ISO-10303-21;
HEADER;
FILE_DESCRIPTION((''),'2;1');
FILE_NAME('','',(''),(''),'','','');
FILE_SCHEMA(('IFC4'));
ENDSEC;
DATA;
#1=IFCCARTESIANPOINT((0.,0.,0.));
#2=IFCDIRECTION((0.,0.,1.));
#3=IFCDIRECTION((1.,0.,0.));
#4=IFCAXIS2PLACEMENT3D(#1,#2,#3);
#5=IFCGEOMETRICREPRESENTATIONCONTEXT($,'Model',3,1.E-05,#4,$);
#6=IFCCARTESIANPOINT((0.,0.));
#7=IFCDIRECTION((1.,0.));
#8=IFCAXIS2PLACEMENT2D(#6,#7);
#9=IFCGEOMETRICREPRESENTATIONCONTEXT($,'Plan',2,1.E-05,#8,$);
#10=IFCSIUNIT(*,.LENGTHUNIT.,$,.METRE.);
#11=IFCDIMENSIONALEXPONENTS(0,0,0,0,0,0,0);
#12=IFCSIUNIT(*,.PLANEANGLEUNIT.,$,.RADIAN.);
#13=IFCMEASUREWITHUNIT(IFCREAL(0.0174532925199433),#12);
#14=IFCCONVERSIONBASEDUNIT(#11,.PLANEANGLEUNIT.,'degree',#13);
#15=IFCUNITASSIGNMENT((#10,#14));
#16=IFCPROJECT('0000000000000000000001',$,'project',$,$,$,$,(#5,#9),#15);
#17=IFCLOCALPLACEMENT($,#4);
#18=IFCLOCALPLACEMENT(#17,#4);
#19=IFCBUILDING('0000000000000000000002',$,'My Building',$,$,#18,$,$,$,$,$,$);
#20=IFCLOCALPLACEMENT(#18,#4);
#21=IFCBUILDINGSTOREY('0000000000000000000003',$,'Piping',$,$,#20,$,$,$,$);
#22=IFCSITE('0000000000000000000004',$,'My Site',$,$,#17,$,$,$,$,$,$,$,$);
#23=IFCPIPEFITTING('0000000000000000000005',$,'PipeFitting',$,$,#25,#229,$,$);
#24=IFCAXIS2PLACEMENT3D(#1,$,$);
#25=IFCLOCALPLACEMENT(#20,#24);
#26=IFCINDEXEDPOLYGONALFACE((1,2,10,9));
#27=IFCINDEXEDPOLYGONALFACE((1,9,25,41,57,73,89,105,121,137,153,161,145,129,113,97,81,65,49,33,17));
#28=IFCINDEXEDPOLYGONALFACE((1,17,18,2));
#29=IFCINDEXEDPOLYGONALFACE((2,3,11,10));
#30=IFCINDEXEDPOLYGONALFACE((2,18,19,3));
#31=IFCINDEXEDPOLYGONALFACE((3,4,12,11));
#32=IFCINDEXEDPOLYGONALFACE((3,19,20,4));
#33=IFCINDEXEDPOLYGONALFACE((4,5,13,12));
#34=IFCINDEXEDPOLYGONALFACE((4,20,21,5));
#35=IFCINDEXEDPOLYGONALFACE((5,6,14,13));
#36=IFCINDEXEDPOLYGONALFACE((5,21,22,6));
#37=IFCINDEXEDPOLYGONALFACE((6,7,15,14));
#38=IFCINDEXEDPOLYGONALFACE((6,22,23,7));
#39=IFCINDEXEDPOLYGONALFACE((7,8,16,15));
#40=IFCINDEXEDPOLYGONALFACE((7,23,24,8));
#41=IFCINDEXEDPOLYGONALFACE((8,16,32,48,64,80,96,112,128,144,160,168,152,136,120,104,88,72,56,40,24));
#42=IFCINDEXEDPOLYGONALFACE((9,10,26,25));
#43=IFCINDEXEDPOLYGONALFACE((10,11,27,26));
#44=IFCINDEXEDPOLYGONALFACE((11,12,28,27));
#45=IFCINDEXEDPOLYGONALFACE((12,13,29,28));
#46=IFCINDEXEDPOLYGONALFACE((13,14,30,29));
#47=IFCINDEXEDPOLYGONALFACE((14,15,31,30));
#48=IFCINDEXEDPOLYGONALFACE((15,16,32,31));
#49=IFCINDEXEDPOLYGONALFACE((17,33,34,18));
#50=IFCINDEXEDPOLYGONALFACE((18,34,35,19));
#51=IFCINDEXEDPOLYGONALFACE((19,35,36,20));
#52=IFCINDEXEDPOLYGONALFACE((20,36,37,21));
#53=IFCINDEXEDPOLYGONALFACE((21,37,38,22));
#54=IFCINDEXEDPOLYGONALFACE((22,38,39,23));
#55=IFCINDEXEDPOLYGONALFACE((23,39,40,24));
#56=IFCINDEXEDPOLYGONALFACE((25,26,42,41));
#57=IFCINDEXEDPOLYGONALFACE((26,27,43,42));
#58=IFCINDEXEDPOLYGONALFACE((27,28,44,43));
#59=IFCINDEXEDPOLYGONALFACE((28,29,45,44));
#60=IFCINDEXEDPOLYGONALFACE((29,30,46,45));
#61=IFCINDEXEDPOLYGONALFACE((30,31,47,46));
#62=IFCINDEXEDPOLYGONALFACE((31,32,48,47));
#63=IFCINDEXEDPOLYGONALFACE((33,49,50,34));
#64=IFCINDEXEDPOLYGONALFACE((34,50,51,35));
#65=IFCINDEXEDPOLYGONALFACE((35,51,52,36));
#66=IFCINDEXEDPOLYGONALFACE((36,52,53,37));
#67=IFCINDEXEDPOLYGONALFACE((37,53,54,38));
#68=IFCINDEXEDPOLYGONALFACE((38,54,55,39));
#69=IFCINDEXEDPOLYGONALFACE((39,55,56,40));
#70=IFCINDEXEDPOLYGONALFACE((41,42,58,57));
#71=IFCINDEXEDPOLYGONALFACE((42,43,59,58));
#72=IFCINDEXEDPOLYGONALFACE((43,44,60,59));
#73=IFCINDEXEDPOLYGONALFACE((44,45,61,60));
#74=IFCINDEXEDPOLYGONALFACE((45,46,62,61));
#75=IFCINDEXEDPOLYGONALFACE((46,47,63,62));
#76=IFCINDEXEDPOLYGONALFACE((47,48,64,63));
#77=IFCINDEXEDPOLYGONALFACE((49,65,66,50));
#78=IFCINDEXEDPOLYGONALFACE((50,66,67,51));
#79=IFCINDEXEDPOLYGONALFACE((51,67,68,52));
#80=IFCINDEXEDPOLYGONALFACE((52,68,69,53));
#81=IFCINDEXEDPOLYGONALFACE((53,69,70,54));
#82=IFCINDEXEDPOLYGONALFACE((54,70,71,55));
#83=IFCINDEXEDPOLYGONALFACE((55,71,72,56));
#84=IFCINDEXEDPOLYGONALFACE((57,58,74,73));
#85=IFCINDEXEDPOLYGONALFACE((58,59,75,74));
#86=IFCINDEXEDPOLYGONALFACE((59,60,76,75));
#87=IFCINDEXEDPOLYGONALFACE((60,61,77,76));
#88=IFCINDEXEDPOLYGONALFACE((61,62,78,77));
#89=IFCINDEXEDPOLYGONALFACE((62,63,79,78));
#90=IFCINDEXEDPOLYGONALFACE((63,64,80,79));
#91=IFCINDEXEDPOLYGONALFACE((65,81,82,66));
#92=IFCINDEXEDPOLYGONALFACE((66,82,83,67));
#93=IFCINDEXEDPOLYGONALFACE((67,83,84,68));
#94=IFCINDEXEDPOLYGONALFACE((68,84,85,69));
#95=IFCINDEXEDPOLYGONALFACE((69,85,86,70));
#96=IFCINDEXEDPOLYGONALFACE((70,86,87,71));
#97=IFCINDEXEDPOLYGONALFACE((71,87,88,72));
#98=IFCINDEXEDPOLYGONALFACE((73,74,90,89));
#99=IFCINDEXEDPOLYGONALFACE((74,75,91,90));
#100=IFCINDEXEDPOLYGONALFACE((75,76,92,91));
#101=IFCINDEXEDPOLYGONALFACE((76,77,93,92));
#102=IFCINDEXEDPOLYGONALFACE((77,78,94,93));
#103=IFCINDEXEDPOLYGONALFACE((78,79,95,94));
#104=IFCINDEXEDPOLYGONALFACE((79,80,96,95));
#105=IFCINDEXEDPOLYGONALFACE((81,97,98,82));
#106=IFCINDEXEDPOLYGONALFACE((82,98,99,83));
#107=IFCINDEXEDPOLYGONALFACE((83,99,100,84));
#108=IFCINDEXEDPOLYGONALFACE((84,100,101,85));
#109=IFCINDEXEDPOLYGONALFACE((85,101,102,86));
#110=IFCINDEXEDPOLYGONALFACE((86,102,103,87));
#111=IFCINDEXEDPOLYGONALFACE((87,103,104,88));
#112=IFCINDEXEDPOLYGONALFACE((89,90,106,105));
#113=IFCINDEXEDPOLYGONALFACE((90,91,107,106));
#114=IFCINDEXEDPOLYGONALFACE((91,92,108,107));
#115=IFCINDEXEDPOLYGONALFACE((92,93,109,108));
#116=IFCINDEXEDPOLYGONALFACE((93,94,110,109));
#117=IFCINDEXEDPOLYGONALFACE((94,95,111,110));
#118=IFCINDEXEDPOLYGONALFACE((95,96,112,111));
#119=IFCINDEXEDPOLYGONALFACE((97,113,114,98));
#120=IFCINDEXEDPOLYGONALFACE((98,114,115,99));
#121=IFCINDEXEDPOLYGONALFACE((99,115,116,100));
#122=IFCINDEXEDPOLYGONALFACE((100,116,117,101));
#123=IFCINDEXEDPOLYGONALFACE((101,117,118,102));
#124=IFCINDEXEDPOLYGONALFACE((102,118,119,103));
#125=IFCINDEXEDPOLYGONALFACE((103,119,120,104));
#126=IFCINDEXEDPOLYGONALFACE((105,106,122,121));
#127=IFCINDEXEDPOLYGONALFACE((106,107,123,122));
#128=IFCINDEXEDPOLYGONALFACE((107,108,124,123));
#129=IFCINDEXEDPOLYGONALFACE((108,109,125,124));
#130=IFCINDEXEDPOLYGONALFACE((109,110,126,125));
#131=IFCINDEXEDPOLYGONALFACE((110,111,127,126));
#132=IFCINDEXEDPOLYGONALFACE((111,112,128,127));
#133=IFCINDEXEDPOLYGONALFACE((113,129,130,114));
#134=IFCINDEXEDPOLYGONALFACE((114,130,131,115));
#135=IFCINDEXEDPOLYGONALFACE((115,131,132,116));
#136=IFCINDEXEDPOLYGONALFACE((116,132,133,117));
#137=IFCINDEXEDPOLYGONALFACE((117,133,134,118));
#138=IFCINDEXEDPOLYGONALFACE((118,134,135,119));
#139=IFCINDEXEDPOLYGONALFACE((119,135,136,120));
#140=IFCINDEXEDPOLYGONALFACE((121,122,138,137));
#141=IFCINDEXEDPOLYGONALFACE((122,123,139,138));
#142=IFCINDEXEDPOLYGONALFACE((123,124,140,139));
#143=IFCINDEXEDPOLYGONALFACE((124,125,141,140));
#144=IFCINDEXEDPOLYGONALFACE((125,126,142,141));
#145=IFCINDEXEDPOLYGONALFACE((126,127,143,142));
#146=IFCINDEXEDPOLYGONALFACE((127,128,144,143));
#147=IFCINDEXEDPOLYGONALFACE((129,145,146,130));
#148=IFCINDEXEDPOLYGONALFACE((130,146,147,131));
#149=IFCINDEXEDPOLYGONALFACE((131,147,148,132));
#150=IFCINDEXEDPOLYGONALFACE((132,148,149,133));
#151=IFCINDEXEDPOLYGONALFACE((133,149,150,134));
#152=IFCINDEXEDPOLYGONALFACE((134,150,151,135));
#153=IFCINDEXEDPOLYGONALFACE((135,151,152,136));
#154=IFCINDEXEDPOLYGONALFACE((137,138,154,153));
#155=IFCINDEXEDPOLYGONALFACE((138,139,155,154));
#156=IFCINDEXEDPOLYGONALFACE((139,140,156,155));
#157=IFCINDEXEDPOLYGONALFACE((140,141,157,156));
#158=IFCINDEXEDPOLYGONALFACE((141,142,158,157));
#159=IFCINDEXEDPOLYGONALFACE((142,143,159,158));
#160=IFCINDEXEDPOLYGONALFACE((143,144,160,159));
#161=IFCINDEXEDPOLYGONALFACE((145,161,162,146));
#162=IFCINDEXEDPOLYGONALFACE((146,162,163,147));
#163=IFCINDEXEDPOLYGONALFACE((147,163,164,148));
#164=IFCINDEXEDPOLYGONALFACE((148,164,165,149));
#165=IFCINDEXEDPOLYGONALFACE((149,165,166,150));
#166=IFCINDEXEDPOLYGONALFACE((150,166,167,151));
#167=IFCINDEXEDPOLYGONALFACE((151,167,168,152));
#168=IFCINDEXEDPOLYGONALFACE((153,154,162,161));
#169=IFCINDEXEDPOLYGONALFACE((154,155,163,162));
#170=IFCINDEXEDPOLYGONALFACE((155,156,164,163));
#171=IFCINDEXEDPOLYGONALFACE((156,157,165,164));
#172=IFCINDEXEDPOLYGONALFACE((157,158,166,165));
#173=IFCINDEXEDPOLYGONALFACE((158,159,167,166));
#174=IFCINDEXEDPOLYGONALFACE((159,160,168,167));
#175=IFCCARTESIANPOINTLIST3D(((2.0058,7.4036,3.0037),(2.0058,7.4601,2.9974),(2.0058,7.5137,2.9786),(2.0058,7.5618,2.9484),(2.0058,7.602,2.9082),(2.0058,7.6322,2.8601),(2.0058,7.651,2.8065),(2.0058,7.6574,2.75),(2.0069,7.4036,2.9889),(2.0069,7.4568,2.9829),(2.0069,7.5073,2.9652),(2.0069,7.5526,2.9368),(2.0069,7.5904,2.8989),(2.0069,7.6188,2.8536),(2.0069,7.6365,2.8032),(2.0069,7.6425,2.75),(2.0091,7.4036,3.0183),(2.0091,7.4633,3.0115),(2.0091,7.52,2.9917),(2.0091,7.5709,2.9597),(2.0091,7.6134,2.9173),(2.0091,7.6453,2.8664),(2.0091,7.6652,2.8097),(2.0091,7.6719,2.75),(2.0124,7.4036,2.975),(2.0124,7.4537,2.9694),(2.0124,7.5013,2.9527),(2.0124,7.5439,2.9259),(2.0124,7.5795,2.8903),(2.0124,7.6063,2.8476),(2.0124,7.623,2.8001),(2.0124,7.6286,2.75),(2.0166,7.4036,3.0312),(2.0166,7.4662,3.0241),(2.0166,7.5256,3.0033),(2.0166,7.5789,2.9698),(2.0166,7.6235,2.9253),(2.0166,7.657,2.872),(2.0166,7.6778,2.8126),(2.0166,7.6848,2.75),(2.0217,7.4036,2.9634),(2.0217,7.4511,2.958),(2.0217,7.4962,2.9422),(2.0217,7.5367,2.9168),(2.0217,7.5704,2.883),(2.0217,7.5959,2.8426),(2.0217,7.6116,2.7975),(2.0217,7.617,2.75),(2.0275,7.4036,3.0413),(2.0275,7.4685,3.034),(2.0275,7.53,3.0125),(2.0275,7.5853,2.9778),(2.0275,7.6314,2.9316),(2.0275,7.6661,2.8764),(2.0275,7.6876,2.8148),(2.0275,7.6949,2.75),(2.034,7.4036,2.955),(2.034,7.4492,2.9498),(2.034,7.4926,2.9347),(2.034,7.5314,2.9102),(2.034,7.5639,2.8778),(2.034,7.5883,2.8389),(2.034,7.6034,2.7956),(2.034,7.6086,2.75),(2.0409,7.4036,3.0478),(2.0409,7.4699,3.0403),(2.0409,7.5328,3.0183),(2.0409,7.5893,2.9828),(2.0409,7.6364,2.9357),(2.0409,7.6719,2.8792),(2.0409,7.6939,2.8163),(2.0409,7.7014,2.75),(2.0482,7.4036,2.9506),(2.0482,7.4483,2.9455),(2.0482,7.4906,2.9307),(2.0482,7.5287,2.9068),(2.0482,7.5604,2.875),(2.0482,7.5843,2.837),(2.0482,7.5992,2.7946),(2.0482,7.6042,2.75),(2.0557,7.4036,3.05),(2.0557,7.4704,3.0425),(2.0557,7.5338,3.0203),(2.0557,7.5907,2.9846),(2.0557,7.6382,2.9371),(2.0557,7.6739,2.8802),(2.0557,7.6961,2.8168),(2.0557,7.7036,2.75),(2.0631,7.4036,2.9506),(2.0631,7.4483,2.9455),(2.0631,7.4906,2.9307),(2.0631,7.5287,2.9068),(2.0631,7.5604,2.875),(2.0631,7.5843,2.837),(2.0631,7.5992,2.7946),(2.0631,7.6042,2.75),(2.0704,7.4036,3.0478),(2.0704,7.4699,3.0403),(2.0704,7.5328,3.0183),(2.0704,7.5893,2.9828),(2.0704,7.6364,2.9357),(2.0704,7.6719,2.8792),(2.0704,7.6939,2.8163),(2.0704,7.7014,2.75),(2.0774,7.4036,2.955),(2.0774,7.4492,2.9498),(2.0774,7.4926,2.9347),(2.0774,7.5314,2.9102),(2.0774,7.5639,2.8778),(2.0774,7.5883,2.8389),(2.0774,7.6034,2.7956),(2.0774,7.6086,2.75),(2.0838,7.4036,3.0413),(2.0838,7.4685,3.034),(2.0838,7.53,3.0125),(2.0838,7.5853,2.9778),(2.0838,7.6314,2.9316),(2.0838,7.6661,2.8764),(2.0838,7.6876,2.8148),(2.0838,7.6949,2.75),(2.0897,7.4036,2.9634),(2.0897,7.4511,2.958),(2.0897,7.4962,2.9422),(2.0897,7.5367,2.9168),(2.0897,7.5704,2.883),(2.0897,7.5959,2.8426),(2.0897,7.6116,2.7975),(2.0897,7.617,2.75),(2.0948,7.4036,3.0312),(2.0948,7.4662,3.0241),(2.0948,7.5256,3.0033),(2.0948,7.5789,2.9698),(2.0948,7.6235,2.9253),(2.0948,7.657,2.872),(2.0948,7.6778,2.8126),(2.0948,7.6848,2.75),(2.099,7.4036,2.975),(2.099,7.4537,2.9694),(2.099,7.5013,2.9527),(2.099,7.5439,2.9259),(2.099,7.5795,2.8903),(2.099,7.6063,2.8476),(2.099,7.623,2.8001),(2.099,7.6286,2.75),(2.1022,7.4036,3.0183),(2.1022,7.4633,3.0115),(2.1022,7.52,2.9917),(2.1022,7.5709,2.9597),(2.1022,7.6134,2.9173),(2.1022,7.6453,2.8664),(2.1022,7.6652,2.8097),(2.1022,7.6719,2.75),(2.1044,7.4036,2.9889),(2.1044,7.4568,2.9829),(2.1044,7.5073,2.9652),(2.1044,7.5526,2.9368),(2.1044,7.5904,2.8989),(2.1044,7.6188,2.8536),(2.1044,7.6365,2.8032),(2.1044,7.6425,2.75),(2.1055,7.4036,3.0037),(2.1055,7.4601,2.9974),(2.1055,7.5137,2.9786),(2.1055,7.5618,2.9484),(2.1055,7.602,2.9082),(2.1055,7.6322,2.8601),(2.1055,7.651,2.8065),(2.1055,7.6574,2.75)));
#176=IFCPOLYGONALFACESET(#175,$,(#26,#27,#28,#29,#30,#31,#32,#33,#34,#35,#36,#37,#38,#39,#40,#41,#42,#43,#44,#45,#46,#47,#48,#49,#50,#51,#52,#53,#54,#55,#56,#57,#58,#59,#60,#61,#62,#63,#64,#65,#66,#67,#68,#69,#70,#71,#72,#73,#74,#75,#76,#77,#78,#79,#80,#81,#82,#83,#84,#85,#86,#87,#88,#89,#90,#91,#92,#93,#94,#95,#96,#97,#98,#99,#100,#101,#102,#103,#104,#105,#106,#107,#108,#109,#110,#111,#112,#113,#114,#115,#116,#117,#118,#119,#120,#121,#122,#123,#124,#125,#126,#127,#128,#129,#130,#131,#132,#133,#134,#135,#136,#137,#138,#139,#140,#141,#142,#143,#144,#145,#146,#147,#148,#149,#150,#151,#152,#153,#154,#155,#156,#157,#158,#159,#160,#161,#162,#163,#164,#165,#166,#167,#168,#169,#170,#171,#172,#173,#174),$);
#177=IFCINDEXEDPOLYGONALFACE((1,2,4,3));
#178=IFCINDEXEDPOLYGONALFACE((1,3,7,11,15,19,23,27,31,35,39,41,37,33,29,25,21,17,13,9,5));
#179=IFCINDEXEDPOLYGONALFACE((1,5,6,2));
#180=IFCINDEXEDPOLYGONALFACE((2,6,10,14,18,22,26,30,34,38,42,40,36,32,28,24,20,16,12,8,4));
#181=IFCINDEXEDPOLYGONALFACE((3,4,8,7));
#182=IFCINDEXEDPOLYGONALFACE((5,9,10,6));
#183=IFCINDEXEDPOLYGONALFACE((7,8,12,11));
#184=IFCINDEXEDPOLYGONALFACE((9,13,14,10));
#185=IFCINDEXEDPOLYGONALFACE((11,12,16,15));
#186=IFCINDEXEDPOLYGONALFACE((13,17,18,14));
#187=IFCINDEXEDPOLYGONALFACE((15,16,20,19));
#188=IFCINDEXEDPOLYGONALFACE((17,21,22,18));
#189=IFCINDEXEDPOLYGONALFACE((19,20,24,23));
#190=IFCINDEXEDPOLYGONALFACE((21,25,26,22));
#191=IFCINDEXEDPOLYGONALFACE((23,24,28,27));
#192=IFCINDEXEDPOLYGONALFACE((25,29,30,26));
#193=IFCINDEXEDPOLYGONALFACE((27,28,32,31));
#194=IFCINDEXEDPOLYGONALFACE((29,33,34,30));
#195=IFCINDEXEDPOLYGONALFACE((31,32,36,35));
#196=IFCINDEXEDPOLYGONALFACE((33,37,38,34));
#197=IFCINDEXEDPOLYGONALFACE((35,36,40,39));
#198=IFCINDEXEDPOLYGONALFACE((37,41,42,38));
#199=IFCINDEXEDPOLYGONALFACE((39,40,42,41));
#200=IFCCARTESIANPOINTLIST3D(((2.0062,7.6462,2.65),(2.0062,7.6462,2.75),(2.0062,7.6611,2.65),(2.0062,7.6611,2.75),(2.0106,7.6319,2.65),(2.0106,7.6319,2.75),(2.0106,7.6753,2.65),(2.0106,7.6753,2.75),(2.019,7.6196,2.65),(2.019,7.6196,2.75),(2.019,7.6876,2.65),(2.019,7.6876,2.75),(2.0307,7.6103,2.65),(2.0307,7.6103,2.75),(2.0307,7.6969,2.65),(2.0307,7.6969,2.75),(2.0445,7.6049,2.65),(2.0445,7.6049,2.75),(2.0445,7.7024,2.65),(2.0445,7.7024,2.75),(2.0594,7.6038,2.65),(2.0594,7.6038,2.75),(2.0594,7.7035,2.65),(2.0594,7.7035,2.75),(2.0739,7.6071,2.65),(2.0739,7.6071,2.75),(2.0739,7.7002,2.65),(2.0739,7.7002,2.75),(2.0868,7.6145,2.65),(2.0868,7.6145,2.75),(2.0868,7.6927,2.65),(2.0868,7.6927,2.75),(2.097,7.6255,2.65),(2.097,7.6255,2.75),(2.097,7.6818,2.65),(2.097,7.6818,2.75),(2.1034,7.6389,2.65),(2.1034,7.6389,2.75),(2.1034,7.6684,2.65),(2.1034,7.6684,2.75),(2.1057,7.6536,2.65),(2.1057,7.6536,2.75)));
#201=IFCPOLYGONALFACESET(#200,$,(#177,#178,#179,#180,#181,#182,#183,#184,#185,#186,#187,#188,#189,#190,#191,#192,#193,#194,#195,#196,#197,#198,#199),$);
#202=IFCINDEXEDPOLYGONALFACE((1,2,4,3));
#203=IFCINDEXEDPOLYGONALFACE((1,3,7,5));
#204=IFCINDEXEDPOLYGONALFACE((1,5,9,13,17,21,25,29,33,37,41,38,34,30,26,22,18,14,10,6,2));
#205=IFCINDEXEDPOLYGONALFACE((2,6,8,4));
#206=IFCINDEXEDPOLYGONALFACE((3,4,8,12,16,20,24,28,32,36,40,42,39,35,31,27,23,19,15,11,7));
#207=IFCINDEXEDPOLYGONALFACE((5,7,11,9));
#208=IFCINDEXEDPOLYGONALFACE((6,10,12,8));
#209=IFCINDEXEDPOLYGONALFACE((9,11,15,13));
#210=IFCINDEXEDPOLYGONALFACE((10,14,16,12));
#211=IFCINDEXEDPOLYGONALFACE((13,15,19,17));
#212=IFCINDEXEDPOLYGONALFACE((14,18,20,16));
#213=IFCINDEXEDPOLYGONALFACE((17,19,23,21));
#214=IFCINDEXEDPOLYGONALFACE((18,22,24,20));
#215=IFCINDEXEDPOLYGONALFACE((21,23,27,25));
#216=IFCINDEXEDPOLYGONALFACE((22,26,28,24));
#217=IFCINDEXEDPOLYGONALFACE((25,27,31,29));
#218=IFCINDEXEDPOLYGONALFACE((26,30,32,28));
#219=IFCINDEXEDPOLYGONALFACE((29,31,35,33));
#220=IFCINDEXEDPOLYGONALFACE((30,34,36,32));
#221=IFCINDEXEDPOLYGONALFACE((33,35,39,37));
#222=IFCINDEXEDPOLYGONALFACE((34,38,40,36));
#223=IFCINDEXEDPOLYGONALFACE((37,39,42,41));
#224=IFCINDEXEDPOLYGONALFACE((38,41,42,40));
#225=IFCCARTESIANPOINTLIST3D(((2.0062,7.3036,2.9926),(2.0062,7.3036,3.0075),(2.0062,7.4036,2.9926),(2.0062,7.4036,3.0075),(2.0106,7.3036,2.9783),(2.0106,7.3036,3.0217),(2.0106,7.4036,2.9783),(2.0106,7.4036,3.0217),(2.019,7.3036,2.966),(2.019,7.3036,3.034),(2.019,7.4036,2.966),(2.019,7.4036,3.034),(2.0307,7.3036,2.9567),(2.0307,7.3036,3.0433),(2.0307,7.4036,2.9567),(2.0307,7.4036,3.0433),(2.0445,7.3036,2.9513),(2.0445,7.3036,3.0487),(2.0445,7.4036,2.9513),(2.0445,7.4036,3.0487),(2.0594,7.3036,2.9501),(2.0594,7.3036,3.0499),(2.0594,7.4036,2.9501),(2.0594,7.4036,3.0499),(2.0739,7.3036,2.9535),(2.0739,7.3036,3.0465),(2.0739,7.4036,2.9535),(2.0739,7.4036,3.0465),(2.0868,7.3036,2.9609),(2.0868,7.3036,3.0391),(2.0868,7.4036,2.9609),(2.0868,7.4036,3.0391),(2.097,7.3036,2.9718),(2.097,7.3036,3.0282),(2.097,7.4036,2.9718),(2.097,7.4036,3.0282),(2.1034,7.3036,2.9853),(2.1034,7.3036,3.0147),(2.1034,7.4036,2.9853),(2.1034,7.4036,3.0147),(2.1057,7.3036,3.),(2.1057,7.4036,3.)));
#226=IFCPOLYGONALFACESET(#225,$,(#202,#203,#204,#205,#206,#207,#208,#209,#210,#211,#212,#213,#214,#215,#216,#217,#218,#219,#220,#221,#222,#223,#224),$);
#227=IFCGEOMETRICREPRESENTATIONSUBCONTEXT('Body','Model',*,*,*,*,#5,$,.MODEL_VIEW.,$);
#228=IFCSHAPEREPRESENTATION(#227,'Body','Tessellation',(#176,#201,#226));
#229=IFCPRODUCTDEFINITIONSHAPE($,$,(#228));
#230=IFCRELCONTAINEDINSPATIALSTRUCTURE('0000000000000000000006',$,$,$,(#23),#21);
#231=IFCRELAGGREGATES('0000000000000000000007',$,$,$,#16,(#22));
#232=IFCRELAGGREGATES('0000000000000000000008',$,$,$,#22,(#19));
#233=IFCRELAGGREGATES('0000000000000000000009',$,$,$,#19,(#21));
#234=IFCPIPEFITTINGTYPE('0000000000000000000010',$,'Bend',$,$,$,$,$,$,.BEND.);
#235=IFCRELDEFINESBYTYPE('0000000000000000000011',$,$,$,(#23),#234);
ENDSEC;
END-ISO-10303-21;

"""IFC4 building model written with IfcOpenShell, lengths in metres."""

from ifc_helpers import new_model, entity, si_unit, converted_unit, frame, origin_with_axes, origin_2d_with_axis, place, context, subcontext, project, spatial, circle, extrude, source, transform, mapped, type_object, type_shapes, element, save


model = new_model("IFC4")

# Units and contexts
model_context = context("Model", 3, precision=1e-05, world=origin_with_axes())
plan_context = context("Plan", 2, precision=1e-05, world=origin_2d_with_axis())
body_context = subcontext(model_context, "Body", "Model", "MODEL_VIEW")
ifc_project = project(units=[si_unit("LENGTHUNIT", "METRE"), converted_unit("PLANEANGLEUNIT", "degree", entity("IfcReal", 0.0174532925199433), si_unit("PLANEANGLEUNIT", "RADIAN"), dimensions=[0, 0, 0, 0, 0, 0, 0])], contexts=[model_context, plan_context])

# Site, building, storey
site_placement = place(None, origin_with_axes())
site = spatial("IfcSite", under=ifc_project, at=site_placement, Name="My Site")
building_placement = place(site_placement, origin_with_axes())
building = spatial("IfcBuilding", under=site, at=building_placement, Name="My Building")
storey_placement = place(building_placement, origin_with_axes())
storey = spatial("IfcBuildingStorey", under=building, at=storey_placement, Name="Piping")

# Pipe fitting
pipe_fitting_type = type_object("IfcPipeFittingType", Name="Bend", PredefinedType="BEND")
shared_shape = source(origin_with_axes(), body_context, "Body", "SolidModel", [
    entity("IfcSweptDiskSolid", entity("IfcIndexedPolyCurve", entity("IfcCartesianPointList3D", [[0.0, 0.0, -0.1], [0.0, 0.0732, -0.2768], [0.0, 0.25, -0.35]]), [entity("IfcArcIndex", [1, 2, 3])]), 0.05),
    extrude(circle(Radius=0.05), origin_with_axes(), (0.0, 0.0, -1.0), 0.1),
    extrude(circle(Radius=0.05), frame((0.0, 0.25, -0.35), z_axis=(0.0, 1.0, 0.0), x_axis=(1.0, 0.0, 0.0)), (0.0, 0.0, 1.0), 0.1),
])
type_shapes(pipe_fitting_type, [shared_shape])
for number, where, z_axis, x_axis, name in (
    (1, (2.0557, 7.6536, 2.65), (0.0, 0.0, -1.0), (1.0, 0.0, 0.0), "PipeFitting"),
):
    element("IfcPipeFitting", number, at=place(storey_placement, frame(where, z_axis=z_axis, x_axis=x_axis)), inside=storey, type_object=pipe_fitting_type, Name=name, context=body_context, shape_type="MappedRepresentation", body=[
        mapped(shared_shape, transform((0.0, 0.0, 0.0), x_axis=(1.0, 0.0, 0.0), y_axis=(0.0, 1.0, 0.0), z_axis=(0.0, 0.0, 1.0), scale=1.0)),
    ])

save(model, "model.ifc")
